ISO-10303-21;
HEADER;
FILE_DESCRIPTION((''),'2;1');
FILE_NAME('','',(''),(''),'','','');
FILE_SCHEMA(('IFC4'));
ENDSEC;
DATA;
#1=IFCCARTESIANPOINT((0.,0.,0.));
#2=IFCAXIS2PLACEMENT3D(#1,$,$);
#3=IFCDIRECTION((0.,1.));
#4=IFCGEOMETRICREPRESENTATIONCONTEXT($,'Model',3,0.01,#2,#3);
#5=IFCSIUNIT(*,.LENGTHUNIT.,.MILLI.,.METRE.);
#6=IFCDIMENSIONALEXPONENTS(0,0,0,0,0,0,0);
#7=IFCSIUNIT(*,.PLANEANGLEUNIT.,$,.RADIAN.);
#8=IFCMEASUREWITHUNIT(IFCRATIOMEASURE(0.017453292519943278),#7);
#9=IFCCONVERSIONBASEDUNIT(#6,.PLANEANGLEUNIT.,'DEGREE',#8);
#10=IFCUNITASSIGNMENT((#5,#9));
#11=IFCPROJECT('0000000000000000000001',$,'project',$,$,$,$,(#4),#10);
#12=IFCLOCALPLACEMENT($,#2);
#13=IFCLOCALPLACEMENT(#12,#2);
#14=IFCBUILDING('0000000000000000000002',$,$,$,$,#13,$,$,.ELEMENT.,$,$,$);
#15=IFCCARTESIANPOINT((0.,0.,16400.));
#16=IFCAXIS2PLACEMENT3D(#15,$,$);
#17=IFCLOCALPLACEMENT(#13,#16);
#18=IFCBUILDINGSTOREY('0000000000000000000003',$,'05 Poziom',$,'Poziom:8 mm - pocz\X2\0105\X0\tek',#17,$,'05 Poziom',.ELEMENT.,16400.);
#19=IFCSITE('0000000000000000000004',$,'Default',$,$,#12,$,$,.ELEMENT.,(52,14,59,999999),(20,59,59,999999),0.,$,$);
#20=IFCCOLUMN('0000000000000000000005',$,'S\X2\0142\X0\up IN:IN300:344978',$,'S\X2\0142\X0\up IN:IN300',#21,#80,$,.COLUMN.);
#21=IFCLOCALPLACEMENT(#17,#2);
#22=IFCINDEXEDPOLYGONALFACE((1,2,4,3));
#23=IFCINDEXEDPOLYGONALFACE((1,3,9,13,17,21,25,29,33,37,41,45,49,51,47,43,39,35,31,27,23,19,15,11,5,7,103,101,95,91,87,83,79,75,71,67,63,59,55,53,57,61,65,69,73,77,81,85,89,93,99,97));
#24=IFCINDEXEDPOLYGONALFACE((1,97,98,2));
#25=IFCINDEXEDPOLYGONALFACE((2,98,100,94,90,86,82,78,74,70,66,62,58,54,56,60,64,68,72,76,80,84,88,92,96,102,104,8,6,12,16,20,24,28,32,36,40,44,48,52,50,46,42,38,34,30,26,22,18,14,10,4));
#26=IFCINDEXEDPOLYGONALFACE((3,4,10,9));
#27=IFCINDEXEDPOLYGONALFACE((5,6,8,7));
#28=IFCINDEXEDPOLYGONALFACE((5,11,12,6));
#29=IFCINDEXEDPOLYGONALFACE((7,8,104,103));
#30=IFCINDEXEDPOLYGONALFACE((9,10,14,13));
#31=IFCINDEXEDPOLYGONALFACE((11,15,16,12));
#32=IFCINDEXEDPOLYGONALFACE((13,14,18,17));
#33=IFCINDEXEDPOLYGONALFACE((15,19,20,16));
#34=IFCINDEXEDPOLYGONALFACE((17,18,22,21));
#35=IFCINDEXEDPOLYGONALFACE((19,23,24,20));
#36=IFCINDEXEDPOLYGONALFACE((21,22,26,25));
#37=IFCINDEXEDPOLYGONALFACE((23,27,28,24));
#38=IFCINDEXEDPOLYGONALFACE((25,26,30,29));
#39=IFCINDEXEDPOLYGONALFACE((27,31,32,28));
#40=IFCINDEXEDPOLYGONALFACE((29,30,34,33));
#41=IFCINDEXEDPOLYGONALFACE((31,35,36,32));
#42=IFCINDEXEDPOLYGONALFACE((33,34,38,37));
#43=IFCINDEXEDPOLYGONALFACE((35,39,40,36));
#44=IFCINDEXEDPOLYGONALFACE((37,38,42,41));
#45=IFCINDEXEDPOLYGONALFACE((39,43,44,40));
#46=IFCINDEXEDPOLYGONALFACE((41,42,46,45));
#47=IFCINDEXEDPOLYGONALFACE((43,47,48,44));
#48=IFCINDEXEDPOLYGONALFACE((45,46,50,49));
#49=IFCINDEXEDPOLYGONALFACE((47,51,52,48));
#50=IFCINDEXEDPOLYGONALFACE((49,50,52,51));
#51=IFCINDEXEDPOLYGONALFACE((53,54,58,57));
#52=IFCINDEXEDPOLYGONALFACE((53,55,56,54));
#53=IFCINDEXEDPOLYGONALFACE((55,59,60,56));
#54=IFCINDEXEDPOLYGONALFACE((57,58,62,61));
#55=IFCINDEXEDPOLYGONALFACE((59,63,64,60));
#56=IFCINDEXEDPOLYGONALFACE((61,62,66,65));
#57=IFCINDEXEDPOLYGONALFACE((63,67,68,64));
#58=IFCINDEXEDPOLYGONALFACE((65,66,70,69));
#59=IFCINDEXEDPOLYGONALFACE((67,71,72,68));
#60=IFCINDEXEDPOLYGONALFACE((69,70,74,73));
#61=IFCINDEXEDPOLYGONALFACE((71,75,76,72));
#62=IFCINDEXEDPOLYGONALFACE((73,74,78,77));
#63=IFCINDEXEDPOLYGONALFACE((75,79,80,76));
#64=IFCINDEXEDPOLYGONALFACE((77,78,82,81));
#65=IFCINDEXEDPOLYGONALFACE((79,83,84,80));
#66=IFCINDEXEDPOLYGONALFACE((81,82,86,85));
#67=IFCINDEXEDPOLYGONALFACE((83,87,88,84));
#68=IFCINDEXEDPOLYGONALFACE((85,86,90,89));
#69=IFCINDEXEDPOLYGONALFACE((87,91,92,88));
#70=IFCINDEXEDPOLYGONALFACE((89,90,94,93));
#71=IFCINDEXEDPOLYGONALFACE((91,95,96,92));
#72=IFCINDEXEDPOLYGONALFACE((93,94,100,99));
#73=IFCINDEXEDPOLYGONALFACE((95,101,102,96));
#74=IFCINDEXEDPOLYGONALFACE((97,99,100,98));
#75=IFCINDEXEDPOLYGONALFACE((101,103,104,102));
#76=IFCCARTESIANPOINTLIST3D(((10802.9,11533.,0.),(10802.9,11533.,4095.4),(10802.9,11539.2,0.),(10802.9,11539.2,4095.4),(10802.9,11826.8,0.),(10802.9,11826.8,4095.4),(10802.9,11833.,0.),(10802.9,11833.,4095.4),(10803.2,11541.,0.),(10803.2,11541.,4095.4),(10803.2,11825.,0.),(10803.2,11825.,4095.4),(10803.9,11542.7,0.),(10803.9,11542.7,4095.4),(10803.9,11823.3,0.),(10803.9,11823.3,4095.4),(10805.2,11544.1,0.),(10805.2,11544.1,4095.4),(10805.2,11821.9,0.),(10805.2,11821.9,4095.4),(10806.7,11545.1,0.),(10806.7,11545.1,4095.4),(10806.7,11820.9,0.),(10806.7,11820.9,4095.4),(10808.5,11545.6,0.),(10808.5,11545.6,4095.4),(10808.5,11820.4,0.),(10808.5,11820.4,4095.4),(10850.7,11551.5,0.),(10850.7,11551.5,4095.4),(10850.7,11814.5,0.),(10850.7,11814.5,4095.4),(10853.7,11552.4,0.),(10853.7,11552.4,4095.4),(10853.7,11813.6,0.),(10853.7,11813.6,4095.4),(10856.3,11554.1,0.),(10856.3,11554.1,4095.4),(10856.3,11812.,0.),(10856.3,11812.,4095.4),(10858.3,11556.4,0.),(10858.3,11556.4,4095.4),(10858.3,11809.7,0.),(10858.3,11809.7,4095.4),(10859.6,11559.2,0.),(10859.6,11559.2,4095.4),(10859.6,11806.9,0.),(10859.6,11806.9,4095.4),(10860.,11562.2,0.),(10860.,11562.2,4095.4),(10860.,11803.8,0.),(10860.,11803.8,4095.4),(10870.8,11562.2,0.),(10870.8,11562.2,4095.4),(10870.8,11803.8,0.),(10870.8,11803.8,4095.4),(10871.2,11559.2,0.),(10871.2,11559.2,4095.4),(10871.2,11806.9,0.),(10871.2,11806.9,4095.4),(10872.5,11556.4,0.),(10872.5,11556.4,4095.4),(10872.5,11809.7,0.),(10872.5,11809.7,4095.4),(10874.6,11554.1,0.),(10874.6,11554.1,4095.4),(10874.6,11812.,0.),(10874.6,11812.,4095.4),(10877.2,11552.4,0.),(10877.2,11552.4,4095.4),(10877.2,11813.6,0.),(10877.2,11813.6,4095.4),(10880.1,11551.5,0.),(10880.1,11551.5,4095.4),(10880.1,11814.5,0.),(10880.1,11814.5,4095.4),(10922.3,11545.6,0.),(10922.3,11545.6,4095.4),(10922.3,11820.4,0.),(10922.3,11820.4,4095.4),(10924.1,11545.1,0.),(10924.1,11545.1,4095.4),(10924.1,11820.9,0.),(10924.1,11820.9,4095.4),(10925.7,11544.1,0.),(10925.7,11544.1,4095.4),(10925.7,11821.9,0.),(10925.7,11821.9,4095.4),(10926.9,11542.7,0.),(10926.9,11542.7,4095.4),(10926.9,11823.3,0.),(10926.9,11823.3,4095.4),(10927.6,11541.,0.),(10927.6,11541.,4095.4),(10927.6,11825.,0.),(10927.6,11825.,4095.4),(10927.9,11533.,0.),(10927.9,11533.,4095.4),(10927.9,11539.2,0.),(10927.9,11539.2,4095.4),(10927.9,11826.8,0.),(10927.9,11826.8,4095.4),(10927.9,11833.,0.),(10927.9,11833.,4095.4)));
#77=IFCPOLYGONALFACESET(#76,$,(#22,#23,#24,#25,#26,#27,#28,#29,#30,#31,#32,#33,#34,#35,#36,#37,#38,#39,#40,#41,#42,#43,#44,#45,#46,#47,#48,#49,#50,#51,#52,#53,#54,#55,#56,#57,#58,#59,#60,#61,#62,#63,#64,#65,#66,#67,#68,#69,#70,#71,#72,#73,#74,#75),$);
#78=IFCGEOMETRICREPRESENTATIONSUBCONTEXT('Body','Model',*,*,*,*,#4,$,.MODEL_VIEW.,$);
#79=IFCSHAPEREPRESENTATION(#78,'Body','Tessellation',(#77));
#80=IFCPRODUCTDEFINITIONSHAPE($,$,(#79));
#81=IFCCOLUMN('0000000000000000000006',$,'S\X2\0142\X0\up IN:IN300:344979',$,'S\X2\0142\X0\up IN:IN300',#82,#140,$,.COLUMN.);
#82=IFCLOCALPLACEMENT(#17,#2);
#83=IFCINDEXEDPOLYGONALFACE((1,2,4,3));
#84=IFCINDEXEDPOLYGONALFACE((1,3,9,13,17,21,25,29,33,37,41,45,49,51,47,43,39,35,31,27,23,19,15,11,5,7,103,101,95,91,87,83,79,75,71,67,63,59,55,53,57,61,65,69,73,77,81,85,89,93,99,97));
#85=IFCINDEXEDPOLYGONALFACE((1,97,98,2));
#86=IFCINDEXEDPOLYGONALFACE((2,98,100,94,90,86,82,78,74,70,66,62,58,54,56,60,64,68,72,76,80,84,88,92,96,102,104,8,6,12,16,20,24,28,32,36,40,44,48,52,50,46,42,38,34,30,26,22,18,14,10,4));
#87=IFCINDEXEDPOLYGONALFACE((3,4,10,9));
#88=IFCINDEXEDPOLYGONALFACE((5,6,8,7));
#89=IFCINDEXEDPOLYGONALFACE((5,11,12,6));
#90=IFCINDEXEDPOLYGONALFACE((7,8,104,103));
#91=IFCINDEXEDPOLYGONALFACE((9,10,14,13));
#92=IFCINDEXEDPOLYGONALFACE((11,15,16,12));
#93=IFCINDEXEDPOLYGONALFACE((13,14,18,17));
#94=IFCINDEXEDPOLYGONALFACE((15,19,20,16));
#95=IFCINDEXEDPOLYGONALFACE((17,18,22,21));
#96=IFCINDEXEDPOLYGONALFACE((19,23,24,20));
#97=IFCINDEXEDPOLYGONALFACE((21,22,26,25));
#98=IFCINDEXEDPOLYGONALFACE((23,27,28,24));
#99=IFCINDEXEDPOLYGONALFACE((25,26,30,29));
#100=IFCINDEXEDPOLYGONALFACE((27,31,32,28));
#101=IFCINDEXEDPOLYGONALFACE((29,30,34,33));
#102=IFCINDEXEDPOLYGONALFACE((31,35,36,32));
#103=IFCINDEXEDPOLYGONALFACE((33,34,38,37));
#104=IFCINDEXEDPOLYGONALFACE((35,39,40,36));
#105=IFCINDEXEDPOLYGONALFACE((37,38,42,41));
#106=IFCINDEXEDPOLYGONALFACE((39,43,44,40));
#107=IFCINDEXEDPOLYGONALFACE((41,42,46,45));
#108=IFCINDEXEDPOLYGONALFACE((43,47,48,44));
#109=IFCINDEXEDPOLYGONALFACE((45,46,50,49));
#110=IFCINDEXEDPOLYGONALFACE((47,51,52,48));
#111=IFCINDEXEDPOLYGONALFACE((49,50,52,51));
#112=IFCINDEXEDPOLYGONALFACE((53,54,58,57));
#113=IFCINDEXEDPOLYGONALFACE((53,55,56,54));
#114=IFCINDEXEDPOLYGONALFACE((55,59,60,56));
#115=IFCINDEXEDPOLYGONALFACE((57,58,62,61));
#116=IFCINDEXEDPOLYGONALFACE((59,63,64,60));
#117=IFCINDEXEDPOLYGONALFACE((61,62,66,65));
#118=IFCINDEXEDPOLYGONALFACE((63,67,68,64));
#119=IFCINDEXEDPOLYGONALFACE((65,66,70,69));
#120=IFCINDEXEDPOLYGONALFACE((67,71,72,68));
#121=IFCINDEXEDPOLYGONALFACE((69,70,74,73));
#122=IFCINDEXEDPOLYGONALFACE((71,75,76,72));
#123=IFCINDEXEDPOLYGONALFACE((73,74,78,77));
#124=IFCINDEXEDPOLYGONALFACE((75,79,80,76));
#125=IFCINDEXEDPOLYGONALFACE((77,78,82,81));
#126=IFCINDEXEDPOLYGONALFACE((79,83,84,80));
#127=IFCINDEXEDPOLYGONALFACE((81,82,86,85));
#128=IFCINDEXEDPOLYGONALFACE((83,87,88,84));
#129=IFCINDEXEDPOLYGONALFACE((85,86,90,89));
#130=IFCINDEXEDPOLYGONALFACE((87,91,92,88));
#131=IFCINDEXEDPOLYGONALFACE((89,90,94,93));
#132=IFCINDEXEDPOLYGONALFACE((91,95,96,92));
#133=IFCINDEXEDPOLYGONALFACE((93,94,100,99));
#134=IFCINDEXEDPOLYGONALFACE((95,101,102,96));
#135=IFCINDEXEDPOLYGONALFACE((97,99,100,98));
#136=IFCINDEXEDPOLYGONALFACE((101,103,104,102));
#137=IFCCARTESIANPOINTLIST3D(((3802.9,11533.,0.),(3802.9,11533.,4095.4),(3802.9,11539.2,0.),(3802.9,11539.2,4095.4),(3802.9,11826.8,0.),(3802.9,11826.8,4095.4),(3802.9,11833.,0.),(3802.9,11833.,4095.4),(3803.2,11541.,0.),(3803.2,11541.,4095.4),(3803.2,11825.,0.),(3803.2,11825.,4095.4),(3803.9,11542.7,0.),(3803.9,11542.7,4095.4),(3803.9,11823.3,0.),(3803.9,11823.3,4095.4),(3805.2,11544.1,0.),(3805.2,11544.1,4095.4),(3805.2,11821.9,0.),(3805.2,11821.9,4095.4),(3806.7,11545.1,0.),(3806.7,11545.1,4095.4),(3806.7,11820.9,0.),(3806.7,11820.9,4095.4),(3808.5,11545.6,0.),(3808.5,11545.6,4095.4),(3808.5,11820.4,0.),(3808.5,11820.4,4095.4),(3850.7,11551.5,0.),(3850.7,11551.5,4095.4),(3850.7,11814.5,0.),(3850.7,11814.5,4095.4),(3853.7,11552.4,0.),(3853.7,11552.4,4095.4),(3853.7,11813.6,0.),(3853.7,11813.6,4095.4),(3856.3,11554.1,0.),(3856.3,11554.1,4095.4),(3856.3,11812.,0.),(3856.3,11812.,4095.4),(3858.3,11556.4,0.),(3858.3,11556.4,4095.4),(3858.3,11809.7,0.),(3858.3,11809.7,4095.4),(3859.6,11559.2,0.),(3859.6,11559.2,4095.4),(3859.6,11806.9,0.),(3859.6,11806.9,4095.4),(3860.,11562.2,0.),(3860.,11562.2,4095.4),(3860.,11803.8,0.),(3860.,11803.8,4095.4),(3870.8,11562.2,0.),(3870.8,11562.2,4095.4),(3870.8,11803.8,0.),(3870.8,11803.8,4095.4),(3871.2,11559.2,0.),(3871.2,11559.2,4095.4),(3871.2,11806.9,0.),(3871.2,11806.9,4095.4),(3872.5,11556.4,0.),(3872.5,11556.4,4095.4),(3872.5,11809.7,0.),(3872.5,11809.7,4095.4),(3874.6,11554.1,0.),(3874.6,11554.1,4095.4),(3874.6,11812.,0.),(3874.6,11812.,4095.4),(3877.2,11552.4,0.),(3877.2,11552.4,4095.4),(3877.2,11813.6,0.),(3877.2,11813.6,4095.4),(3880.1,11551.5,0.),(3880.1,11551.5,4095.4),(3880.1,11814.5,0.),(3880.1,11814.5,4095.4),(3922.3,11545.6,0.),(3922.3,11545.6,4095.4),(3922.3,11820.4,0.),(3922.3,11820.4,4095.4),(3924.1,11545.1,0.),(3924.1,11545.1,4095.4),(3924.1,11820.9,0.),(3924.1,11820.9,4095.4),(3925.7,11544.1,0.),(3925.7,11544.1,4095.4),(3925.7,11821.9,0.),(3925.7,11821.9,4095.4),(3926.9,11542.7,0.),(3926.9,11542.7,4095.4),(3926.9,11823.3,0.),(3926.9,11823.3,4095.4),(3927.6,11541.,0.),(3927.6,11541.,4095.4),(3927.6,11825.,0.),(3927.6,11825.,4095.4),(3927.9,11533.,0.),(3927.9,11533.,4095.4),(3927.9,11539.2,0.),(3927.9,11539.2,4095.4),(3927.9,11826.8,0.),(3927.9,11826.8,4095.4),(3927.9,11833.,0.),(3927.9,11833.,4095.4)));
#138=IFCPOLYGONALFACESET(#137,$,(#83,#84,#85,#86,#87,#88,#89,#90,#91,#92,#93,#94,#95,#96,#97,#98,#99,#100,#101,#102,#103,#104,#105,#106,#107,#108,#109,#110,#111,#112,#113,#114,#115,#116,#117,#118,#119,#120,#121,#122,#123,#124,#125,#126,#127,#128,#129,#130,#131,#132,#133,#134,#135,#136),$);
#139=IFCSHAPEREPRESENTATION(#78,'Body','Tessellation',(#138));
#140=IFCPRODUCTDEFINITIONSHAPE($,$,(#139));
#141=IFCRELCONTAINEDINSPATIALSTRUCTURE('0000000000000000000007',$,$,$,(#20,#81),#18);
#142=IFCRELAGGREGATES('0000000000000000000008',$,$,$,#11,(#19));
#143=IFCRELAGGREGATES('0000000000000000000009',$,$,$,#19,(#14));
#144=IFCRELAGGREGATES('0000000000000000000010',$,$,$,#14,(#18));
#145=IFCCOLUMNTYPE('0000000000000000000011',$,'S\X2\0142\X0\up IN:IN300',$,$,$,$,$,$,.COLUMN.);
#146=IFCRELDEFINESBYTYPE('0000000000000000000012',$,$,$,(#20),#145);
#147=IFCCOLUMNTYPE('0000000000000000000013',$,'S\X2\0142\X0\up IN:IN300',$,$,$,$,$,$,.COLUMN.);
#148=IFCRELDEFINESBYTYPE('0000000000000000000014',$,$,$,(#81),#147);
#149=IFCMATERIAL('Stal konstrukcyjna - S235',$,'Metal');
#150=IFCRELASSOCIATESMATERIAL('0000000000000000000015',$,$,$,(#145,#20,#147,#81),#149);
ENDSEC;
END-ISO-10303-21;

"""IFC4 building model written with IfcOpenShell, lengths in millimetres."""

from ifc_helpers import new_model, entity, si_unit, converted_unit, direction, frame, origin, place, context, subcontext, project, spatial, line, arc, indexed_curve, outline, extrude, source, transform, mapped, material, type_object, type_shapes, element, save


model = new_model("IFC4")

# Units and contexts
model_context = context("Model", 3, precision=0.01, world=origin(), true_north=direction((0.0, 1.0)))
body_context = subcontext(model_context, "Body", "Model", "MODEL_VIEW")
ifc_project = project(units=[si_unit("LENGTHUNIT", "METRE", prefix="MILLI"), converted_unit("PLANEANGLEUNIT", "DEGREE", entity("IfcRatioMeasure", 0.017453292519943278), si_unit("PLANEANGLEUNIT", "RADIAN"), dimensions=[0, 0, 0, 0, 0, 0, 0])], contexts=[model_context])

# Site, building, storey
site_placement = place(None, origin())
site = spatial("IfcSite", under=ifc_project, at=site_placement, Name="Default", CompositionType="ELEMENT", RefLatitude=(52, 14, 59, 999999), RefLongitude=(20, 59, 59, 999999), RefElevation=0.0)
building_placement = place(site_placement, origin())
building = spatial("IfcBuilding", under=site, at=building_placement, CompositionType="ELEMENT")
storey_placement = place(building_placement, frame((0.0, 0.0, 16400.0)))
storey = spatial("IfcBuildingStorey", under=building, at=storey_placement, Name="05 Poziom", ObjectType="Poziom:8 mm - początek", LongName="05 Poziom", CompositionType="ELEMENT", Elevation=16400.0)

# Columns
ifc_material = material(Name="Stal konstrukcyjna - S235", Category="Metal")
column_type_1 = type_object("IfcColumnType", Name="Słup IN:IN300", PredefinedType="COLUMN", material=ifc_material)
shared_shape_1 = source(origin(), body_context, "Body", "SweptSolid", [
    extrude(outline(indexed_curve([(143.8, -62.5), (150.0, -62.5), (150.0, 62.5), (143.8, 62.5), (139.6, 60.9), (137.4, 56.9), (131.5, 14.7), (127.9, 8.1), (120.8, 5.4), (-120.8, 5.4), (-127.9, 8.1), (-131.5, 14.7), (-137.4, 56.9), (-139.6, 60.9), (-143.8, 62.5), (-150.0, 62.5), (-150.0, -62.5), (-143.8, -62.5), (-139.6, -60.9), (-137.4, -56.9), (-131.5, -14.7), (-127.9, -8.1), (-120.8, -5.4), (120.8, -5.4), (127.9, -8.1), (131.5, -14.7), (137.4, -56.9), (139.6, -60.9)], segments=[line(1, 2, 3, 4), arc(4, 5, 6), line(6, 7), arc(7, 8, 9), line(9, 10), arc(10, 11, 12), line(12, 13), arc(13, 14, 15), line(15, 16, 17, 18), arc(18, 19, 20), line(20, 21), arc(21, 22, 23), line(23, 24), arc(24, 25, 26), line(26, 27), arc(27, 28, 1)], self_intersect=False)), frame((10865.4, 11683.0, 16400.0), z_axis=(0.0, 0.0, 1.0), x_axis=(0.0, -1.0, 0.0)), (0.0, 0.0, 1.0), 4095.4),
])
type_shapes(column_type_1, [shared_shape_1])
column_1_placement = place(storey_placement, frame((0.0, 0.0, -16400.0)))
element("IfcColumn", 1, at=column_1_placement, inside=storey, type_object=column_type_1, material=ifc_material, Name="Słup IN:IN300:344978", ObjectType="Słup IN:IN300", PredefinedType="COLUMN", context=body_context, shape_type="MappedRepresentation", body=[
    mapped(shared_shape_1, transform((0.0, 0.0, 0.0), scale=1.0)),
])
column_type_2 = type_object("IfcColumnType", Name="Słup IN:IN300", PredefinedType="COLUMN", material=ifc_material)
shared_shape_2 = source(origin(), body_context, "Body", "SweptSolid", [
    extrude(outline(indexed_curve([(143.8, -62.5), (150.0, -62.5), (150.0, 62.5), (143.8, 62.5), (139.6, 60.9), (137.4, 56.9), (131.5, 14.7), (127.9, 8.1), (120.8, 5.4), (-120.8, 5.4), (-127.9, 8.1), (-131.5, 14.7), (-137.4, 56.9), (-139.6, 60.9), (-143.8, 62.5), (-150.0, 62.5), (-150.0, -62.5), (-143.8, -62.5), (-139.6, -60.9), (-137.4, -56.9), (-131.5, -14.7), (-127.9, -8.1), (-120.8, -5.4), (120.8, -5.4), (127.9, -8.1), (131.5, -14.7), (137.4, -56.9), (139.6, -60.9)], segments=[line(1, 2, 3, 4), arc(4, 5, 6), line(6, 7), arc(7, 8, 9), line(9, 10), arc(10, 11, 12), line(12, 13), arc(13, 14, 15), line(15, 16, 17, 18), arc(18, 19, 20), line(20, 21), arc(21, 22, 23), line(23, 24), arc(24, 25, 26), line(26, 27), arc(27, 28, 1)], self_intersect=False)), frame((3865.4, 11683.0, 16400.0), z_axis=(0.0, 0.0, 1.0), x_axis=(0.0, -1.0, 0.0)), (0.0, 0.0, 1.0), 4095.4),
])
type_shapes(column_type_2, [shared_shape_2])
column_2_placement = place(storey_placement, frame((0.0, 0.0, -16400.0)))
element("IfcColumn", 2, at=column_2_placement, inside=storey, type_object=column_type_2, material=ifc_material, Name="Słup IN:IN300:344979", ObjectType="Słup IN:IN300", PredefinedType="COLUMN", context=body_context, shape_type="MappedRepresentation", body=[
    mapped(shared_shape_2, transform((0.0, 0.0, 0.0), scale=1.0)),
])

save(model, "model.ifc")
